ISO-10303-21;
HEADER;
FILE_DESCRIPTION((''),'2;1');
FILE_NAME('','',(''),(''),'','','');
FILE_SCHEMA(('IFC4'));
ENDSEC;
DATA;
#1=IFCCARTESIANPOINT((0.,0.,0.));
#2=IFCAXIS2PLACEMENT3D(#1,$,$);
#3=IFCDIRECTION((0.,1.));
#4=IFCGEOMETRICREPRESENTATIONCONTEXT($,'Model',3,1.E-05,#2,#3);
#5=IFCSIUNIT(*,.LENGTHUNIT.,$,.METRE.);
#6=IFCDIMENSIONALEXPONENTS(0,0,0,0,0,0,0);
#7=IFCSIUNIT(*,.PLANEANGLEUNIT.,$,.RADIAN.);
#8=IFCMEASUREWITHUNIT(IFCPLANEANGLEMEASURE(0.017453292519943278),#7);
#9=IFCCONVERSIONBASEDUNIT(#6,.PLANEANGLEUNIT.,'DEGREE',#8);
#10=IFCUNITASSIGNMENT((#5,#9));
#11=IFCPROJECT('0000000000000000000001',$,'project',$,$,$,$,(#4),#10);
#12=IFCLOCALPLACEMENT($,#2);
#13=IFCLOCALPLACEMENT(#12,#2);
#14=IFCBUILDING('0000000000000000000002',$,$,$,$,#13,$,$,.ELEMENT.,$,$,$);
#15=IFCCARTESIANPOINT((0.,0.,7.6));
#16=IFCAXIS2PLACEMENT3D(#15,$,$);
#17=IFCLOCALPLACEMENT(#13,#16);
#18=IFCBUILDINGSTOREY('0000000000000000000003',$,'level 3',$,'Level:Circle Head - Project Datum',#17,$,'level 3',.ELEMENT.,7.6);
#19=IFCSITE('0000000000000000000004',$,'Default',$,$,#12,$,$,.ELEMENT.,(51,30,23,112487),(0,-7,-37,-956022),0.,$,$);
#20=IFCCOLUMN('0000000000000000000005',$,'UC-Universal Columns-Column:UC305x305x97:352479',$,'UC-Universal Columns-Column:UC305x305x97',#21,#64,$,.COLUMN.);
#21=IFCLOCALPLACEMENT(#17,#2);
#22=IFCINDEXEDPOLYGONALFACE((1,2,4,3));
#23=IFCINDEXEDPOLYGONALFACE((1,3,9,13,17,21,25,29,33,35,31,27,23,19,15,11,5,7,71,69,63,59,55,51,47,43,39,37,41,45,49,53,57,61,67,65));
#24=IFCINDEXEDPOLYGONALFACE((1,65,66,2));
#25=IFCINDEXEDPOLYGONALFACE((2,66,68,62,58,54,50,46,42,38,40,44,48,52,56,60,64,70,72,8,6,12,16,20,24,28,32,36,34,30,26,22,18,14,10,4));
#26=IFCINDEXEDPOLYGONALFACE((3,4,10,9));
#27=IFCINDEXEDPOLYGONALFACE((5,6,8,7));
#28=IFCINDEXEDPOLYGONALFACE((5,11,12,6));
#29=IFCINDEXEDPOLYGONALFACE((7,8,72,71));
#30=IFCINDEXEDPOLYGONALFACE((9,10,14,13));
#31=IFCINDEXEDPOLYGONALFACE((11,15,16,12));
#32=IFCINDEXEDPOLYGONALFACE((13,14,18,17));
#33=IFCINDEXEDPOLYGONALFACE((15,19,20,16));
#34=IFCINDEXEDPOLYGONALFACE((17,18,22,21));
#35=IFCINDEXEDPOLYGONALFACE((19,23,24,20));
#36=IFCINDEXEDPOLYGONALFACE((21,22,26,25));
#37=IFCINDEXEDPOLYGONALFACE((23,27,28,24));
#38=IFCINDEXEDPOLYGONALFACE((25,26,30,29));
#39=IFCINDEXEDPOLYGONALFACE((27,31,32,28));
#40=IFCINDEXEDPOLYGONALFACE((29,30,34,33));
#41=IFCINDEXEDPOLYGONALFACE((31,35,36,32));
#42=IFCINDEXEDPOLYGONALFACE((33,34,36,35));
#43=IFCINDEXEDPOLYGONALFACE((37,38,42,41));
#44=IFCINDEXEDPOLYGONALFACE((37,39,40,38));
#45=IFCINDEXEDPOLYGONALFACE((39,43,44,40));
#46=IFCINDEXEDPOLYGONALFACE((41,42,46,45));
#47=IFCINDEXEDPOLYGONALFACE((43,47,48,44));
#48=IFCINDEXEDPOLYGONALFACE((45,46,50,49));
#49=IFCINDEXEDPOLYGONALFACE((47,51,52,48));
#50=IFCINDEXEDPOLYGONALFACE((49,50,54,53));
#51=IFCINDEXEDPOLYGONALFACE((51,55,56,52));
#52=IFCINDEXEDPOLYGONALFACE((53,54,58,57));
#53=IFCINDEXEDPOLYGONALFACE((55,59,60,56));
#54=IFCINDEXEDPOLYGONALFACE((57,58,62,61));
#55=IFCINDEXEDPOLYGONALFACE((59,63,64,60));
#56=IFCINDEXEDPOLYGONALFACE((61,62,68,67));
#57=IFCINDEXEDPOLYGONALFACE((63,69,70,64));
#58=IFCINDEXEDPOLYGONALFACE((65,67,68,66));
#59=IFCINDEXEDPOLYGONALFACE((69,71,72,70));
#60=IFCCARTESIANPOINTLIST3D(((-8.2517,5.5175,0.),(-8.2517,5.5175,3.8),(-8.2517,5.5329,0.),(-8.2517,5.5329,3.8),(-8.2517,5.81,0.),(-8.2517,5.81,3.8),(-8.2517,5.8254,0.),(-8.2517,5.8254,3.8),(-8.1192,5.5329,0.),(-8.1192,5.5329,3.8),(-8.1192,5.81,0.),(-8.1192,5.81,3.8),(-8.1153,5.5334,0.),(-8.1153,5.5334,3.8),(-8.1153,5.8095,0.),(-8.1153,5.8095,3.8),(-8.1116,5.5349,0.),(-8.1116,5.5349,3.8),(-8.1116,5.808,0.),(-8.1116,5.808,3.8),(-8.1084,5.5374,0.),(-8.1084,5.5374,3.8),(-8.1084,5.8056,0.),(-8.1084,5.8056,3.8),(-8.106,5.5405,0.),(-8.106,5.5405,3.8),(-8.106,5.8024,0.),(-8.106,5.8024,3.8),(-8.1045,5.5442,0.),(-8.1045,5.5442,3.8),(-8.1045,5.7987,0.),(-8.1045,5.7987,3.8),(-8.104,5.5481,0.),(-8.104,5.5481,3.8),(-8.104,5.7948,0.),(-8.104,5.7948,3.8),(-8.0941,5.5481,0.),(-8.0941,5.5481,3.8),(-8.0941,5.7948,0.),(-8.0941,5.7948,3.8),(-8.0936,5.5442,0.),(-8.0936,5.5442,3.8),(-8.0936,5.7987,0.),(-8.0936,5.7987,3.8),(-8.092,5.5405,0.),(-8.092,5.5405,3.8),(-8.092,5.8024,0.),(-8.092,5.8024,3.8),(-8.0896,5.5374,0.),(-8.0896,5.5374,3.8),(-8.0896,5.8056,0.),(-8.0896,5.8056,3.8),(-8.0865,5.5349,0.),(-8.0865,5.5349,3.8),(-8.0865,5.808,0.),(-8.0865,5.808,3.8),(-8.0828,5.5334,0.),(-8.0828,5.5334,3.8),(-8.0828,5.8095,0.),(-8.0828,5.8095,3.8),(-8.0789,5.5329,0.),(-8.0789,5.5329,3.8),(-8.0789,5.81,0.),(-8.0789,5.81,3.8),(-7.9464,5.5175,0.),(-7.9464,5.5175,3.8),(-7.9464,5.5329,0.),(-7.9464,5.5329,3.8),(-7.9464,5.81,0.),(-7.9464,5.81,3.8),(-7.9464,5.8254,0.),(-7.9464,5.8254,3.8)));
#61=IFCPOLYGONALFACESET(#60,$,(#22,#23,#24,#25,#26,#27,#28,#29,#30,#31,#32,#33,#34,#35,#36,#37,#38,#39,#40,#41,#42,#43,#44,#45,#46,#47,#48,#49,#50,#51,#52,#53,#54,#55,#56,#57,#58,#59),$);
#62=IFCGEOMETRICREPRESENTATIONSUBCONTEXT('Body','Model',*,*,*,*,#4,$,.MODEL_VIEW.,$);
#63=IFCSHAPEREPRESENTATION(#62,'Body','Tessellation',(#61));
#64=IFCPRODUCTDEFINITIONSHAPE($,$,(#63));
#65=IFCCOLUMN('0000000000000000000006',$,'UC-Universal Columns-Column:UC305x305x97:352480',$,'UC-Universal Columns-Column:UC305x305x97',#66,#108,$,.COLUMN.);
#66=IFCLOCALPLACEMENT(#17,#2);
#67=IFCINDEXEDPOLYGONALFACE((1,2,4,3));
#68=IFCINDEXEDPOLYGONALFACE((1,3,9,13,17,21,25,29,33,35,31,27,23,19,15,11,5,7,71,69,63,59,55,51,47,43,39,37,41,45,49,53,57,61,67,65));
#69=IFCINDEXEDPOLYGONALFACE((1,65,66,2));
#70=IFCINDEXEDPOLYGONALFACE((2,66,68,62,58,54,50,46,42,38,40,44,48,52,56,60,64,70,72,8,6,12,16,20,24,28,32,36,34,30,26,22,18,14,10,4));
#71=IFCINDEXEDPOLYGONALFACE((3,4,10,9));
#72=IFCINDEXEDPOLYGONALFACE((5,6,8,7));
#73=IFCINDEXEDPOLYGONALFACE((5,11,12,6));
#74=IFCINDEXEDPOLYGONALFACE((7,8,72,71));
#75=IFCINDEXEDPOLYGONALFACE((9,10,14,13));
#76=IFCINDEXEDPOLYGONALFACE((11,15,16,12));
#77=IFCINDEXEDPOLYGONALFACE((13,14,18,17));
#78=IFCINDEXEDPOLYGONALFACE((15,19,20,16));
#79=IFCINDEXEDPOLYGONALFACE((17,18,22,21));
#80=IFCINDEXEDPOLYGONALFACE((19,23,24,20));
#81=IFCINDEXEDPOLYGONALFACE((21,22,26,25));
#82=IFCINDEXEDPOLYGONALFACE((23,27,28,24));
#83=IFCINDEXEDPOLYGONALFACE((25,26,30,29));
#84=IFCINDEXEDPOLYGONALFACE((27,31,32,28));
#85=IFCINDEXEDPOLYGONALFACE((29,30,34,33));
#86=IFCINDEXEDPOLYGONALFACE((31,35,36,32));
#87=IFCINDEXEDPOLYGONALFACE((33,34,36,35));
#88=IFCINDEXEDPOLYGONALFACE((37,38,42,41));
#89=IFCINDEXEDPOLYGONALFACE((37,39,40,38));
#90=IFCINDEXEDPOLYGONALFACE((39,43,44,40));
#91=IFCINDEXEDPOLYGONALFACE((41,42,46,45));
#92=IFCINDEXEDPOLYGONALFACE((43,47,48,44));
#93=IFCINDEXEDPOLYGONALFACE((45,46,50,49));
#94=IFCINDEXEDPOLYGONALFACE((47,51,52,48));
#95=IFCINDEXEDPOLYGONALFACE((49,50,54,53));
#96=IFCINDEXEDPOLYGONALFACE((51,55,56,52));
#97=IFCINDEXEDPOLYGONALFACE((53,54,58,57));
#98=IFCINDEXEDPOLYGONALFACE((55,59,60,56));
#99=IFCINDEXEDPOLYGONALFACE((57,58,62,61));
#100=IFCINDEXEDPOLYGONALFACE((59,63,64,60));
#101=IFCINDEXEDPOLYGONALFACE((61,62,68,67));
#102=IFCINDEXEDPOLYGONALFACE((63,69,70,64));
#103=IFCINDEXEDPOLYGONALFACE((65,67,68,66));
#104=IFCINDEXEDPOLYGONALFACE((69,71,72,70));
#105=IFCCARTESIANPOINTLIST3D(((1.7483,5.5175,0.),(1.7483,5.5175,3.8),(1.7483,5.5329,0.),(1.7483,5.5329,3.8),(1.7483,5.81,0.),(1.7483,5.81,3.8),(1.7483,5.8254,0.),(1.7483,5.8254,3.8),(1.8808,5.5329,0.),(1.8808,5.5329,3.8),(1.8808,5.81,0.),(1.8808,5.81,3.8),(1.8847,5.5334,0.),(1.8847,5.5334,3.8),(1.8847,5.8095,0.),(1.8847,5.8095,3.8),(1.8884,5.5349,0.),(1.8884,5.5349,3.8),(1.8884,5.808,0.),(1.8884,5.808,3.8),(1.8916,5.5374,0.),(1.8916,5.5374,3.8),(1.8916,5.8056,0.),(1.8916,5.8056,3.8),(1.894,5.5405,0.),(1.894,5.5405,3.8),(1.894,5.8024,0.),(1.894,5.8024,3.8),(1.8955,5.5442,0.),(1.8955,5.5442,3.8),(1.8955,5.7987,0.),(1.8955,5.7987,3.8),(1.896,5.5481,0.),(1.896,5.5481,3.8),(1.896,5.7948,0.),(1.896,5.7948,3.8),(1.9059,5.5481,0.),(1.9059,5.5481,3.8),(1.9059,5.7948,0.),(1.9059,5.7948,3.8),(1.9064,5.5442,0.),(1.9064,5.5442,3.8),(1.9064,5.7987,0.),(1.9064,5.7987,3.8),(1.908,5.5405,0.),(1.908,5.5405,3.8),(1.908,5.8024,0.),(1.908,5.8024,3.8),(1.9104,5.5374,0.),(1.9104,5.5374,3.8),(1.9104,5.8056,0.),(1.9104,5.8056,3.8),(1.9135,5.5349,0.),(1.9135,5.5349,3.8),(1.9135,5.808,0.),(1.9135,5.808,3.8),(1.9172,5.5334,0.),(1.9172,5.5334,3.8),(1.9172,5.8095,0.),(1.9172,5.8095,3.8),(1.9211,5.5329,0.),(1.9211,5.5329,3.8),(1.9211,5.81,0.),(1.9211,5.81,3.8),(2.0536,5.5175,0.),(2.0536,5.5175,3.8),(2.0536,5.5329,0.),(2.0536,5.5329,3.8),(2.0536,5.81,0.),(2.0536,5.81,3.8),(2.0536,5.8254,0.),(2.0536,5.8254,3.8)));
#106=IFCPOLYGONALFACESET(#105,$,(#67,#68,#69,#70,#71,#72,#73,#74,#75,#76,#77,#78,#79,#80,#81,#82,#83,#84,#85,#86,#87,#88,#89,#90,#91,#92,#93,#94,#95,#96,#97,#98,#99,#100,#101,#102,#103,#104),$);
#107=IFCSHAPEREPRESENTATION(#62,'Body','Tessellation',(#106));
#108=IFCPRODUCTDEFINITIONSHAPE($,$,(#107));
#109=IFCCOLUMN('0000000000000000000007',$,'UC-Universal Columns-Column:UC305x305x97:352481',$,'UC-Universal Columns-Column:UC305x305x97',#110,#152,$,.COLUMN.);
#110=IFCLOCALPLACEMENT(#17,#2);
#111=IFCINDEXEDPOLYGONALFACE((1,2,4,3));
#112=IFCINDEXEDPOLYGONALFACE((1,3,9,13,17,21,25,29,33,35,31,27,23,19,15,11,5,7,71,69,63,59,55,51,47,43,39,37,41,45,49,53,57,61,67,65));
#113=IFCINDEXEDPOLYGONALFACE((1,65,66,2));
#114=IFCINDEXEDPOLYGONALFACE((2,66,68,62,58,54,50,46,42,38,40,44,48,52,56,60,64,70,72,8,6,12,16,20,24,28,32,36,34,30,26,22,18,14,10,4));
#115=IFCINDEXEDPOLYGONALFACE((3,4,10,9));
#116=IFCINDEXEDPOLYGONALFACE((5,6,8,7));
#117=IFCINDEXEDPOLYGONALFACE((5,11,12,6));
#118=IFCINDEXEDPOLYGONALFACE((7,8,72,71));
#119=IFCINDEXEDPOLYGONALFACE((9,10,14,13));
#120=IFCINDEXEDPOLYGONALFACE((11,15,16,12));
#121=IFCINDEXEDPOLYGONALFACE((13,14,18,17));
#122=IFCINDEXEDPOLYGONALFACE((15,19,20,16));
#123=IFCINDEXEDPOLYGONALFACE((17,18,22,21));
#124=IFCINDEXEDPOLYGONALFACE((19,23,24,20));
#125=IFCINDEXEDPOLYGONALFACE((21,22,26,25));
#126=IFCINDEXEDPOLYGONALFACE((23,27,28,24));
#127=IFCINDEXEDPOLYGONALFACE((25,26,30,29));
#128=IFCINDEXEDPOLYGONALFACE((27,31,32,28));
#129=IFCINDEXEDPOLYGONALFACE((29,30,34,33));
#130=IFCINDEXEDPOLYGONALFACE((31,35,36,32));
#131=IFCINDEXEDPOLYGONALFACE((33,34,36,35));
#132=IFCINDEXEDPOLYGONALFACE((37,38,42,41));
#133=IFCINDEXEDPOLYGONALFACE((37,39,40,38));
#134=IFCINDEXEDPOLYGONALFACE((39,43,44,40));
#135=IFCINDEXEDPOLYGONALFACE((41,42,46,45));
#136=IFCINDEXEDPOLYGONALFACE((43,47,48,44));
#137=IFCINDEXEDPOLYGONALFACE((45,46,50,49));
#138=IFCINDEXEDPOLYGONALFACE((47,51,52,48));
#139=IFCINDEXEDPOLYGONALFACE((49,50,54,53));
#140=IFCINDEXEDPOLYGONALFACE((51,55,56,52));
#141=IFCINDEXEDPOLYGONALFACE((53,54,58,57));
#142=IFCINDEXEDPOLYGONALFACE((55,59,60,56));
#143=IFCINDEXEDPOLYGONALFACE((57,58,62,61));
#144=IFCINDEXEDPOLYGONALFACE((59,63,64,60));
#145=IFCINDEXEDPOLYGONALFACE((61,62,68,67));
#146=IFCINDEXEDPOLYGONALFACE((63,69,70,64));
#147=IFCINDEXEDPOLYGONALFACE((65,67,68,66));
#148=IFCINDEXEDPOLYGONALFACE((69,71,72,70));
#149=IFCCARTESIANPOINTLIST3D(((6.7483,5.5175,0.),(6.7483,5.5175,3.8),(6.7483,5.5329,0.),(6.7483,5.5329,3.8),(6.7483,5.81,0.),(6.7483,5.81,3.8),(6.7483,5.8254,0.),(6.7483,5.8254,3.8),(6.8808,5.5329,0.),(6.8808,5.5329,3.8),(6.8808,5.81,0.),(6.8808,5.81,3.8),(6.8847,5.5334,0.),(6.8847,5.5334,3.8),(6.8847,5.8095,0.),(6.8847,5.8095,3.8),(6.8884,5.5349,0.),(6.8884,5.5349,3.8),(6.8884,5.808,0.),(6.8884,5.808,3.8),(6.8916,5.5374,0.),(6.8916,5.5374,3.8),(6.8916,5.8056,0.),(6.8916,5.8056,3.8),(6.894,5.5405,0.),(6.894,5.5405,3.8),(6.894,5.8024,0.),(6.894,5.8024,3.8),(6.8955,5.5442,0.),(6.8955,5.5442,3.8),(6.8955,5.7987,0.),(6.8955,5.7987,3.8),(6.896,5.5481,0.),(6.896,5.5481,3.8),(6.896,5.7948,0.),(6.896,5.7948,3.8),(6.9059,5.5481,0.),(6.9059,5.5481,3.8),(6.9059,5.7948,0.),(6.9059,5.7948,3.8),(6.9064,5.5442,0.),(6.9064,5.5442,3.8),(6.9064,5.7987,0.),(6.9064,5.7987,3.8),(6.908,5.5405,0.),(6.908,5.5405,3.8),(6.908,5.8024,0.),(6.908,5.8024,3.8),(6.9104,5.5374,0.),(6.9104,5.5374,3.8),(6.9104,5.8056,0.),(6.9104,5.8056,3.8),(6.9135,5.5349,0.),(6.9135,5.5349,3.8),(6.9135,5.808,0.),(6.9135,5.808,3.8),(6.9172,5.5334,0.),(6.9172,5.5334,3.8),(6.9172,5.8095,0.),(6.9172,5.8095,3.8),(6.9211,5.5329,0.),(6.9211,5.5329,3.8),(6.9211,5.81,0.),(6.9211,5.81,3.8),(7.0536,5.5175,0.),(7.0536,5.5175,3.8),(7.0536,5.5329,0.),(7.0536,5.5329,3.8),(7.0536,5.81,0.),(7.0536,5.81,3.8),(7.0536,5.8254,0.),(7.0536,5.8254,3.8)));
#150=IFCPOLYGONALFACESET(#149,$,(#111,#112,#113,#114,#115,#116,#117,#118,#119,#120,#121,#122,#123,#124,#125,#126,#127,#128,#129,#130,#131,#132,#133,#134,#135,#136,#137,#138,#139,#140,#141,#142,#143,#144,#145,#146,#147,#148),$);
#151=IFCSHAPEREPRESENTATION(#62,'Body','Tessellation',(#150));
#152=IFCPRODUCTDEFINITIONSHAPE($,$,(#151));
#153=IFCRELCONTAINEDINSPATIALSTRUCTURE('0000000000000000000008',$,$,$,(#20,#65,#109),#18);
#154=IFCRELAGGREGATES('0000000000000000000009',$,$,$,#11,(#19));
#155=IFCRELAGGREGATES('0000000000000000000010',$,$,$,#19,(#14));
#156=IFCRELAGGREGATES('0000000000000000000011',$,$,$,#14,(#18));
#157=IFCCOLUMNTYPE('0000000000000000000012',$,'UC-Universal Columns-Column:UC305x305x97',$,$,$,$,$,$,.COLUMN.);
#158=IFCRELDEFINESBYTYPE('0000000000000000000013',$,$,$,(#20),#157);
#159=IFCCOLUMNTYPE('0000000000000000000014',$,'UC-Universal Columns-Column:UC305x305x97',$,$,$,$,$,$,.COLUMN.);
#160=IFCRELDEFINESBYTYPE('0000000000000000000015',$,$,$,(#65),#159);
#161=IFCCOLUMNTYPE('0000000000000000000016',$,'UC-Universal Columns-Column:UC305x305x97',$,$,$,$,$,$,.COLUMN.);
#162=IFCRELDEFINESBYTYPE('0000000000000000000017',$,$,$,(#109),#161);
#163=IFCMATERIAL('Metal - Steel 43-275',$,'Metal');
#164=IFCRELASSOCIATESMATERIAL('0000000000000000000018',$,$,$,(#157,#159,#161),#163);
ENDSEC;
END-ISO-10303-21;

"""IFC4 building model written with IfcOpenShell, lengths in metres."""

from ifc_helpers import new_model, entity, si_unit, converted_unit, direction, frame, frame_2d, origin, place, context, subcontext, project, spatial, i_section, extrude, source, transform, mapped, material, material_profile, profile_set, type_object, type_shapes, element, save


model = new_model("IFC4")

# Units and contexts
model_context = context("Model", 3, precision=1e-05, world=origin(), true_north=direction((0.0, 1.0)))
body_context = subcontext(model_context, "Body", "Model", "MODEL_VIEW")
ifc_project = project(units=[si_unit("LENGTHUNIT", "METRE"), converted_unit("PLANEANGLEUNIT", "DEGREE", entity("IfcPlaneAngleMeasure", 0.017453292519943278), si_unit("PLANEANGLEUNIT", "RADIAN"), dimensions=[0, 0, 0, 0, 0, 0, 0])], contexts=[model_context])

# Site, building, storey
site_placement = place(None, origin())
site = spatial("IfcSite", under=ifc_project, at=site_placement, Name="Default", CompositionType="ELEMENT", RefLatitude=(51, 30, 23, 112487), RefLongitude=(0, -7, -37, -956022), RefElevation=0.0)
building_placement = place(site_placement, origin())
building = spatial("IfcBuilding", under=site, at=building_placement, CompositionType="ELEMENT")
storey_placement = place(building_placement, frame((0.0, 0.0, 7.6)))
storey = spatial("IfcBuildingStorey", under=building, at=storey_placement, Name="level 3", ObjectType="Level:Circle Head - Project Datum", LongName="level 3", CompositionType="ELEMENT", Elevation=7.6)

# Columns
ifc_material_1 = material(Name="Metal - Steel 43-275", Category="Metal")
ifc_material_profile_1 = material_profile(ifc_material_1, i_section(OverallWidth=0.3053, OverallDepth=0.3079, WebThickness=0.0099, FlangeThickness=0.0154, FilletRadius=0.0152, at=frame_2d((0.0, 0.0), x_axis=(1.0, 0.0))), Name="UC305x305x97")
ifc_profile_set_1 = profile_set([ifc_material_profile_1], Name="UC305x305x97")
column_type_1 = type_object("IfcColumnType", Name="UC-Universal Columns-Column:UC305x305x97", PredefinedType="COLUMN", material=ifc_profile_set_1)
shared_shape_1 = source(origin(), body_context, "Body", "SweptSolid", [
    extrude(i_section(OverallWidth=0.3053, OverallDepth=0.3079, WebThickness=0.0099, FlangeThickness=0.0154, FilletRadius=0.0152, at=frame_2d((0.0, 0.0), x_axis=(1.0, 0.0))), frame((-8.099, 5.6715, 7.6), z_axis=(0.0, 0.0, 1.0), x_axis=(-1.0, 0.0, 0.0)), (0.0, 0.0, 1.0), 3.8),
])
type_shapes(column_type_1, [shared_shape_1])
column_1_placement = place(storey_placement, frame((0.0, 0.0, -7.6)))
element("IfcColumn", 1, at=column_1_placement, inside=storey, type_object=column_type_1, Name="UC-Universal Columns-Column:UC305x305x97:352479", ObjectType="UC-Universal Columns-Column:UC305x305x97", PredefinedType="COLUMN", context=body_context, shape_type="MappedRepresentation", body=[
    mapped(shared_shape_1, transform((0.0, 0.0, 0.0), scale=1.0)),
])
column_type_2 = type_object("IfcColumnType", Name="UC-Universal Columns-Column:UC305x305x97", PredefinedType="COLUMN", material=ifc_profile_set_1)
shared_shape_2 = source(origin(), body_context, "Body", "SweptSolid", [
    extrude(i_section(OverallWidth=0.3053, OverallDepth=0.3079, WebThickness=0.0099, FlangeThickness=0.0154, FilletRadius=0.0152, at=frame_2d((0.0, 0.0), x_axis=(1.0, 0.0))), frame((1.901, 5.6715, 7.6), z_axis=(0.0, 0.0, 1.0), x_axis=(-1.0, 0.0, 0.0)), (0.0, 0.0, 1.0), 3.8),
])
type_shapes(column_type_2, [shared_shape_2])
column_2_placement = place(storey_placement, frame((0.0, 0.0, -7.6)))
element("IfcColumn", 2, at=column_2_placement, inside=storey, type_object=column_type_2, Name="UC-Universal Columns-Column:UC305x305x97:352480", ObjectType="UC-Universal Columns-Column:UC305x305x97", PredefinedType="COLUMN", context=body_context, shape_type="MappedRepresentation", body=[
    mapped(shared_shape_2, transform((0.0, 0.0, 0.0), scale=1.0)),
])
column_type_3 = type_object("IfcColumnType", Name="UC-Universal Columns-Column:UC305x305x97", PredefinedType="COLUMN", material=ifc_profile_set_1)
shared_shape_3 = source(origin(), body_context, "Body", "SweptSolid", [
    extrude(i_section(OverallWidth=0.3053, OverallDepth=0.3079, WebThickness=0.0099, FlangeThickness=0.0154, FilletRadius=0.0152, at=frame_2d((0.0, 0.0), x_axis=(1.0, 0.0))), frame((6.901, 5.6715, 7.6), z_axis=(0.0, 0.0, 1.0), x_axis=(-1.0, 0.0, 0.0)), (0.0, 0.0, 1.0), 3.8),
])
type_shapes(column_type_3, [shared_shape_3])
column_3_placement = place(storey_placement, frame((0.0, 0.0, -7.6)))
element("IfcColumn", 3, at=column_3_placement, inside=storey, type_object=column_type_3, Name="UC-Universal Columns-Column:UC305x305x97:352481", ObjectType="UC-Universal Columns-Column:UC305x305x97", PredefinedType="COLUMN", context=body_context, shape_type="MappedRepresentation", body=[
    mapped(shared_shape_3, transform((0.0, 0.0, 0.0), scale=1.0)),
])

save(model, "model.ifc")
